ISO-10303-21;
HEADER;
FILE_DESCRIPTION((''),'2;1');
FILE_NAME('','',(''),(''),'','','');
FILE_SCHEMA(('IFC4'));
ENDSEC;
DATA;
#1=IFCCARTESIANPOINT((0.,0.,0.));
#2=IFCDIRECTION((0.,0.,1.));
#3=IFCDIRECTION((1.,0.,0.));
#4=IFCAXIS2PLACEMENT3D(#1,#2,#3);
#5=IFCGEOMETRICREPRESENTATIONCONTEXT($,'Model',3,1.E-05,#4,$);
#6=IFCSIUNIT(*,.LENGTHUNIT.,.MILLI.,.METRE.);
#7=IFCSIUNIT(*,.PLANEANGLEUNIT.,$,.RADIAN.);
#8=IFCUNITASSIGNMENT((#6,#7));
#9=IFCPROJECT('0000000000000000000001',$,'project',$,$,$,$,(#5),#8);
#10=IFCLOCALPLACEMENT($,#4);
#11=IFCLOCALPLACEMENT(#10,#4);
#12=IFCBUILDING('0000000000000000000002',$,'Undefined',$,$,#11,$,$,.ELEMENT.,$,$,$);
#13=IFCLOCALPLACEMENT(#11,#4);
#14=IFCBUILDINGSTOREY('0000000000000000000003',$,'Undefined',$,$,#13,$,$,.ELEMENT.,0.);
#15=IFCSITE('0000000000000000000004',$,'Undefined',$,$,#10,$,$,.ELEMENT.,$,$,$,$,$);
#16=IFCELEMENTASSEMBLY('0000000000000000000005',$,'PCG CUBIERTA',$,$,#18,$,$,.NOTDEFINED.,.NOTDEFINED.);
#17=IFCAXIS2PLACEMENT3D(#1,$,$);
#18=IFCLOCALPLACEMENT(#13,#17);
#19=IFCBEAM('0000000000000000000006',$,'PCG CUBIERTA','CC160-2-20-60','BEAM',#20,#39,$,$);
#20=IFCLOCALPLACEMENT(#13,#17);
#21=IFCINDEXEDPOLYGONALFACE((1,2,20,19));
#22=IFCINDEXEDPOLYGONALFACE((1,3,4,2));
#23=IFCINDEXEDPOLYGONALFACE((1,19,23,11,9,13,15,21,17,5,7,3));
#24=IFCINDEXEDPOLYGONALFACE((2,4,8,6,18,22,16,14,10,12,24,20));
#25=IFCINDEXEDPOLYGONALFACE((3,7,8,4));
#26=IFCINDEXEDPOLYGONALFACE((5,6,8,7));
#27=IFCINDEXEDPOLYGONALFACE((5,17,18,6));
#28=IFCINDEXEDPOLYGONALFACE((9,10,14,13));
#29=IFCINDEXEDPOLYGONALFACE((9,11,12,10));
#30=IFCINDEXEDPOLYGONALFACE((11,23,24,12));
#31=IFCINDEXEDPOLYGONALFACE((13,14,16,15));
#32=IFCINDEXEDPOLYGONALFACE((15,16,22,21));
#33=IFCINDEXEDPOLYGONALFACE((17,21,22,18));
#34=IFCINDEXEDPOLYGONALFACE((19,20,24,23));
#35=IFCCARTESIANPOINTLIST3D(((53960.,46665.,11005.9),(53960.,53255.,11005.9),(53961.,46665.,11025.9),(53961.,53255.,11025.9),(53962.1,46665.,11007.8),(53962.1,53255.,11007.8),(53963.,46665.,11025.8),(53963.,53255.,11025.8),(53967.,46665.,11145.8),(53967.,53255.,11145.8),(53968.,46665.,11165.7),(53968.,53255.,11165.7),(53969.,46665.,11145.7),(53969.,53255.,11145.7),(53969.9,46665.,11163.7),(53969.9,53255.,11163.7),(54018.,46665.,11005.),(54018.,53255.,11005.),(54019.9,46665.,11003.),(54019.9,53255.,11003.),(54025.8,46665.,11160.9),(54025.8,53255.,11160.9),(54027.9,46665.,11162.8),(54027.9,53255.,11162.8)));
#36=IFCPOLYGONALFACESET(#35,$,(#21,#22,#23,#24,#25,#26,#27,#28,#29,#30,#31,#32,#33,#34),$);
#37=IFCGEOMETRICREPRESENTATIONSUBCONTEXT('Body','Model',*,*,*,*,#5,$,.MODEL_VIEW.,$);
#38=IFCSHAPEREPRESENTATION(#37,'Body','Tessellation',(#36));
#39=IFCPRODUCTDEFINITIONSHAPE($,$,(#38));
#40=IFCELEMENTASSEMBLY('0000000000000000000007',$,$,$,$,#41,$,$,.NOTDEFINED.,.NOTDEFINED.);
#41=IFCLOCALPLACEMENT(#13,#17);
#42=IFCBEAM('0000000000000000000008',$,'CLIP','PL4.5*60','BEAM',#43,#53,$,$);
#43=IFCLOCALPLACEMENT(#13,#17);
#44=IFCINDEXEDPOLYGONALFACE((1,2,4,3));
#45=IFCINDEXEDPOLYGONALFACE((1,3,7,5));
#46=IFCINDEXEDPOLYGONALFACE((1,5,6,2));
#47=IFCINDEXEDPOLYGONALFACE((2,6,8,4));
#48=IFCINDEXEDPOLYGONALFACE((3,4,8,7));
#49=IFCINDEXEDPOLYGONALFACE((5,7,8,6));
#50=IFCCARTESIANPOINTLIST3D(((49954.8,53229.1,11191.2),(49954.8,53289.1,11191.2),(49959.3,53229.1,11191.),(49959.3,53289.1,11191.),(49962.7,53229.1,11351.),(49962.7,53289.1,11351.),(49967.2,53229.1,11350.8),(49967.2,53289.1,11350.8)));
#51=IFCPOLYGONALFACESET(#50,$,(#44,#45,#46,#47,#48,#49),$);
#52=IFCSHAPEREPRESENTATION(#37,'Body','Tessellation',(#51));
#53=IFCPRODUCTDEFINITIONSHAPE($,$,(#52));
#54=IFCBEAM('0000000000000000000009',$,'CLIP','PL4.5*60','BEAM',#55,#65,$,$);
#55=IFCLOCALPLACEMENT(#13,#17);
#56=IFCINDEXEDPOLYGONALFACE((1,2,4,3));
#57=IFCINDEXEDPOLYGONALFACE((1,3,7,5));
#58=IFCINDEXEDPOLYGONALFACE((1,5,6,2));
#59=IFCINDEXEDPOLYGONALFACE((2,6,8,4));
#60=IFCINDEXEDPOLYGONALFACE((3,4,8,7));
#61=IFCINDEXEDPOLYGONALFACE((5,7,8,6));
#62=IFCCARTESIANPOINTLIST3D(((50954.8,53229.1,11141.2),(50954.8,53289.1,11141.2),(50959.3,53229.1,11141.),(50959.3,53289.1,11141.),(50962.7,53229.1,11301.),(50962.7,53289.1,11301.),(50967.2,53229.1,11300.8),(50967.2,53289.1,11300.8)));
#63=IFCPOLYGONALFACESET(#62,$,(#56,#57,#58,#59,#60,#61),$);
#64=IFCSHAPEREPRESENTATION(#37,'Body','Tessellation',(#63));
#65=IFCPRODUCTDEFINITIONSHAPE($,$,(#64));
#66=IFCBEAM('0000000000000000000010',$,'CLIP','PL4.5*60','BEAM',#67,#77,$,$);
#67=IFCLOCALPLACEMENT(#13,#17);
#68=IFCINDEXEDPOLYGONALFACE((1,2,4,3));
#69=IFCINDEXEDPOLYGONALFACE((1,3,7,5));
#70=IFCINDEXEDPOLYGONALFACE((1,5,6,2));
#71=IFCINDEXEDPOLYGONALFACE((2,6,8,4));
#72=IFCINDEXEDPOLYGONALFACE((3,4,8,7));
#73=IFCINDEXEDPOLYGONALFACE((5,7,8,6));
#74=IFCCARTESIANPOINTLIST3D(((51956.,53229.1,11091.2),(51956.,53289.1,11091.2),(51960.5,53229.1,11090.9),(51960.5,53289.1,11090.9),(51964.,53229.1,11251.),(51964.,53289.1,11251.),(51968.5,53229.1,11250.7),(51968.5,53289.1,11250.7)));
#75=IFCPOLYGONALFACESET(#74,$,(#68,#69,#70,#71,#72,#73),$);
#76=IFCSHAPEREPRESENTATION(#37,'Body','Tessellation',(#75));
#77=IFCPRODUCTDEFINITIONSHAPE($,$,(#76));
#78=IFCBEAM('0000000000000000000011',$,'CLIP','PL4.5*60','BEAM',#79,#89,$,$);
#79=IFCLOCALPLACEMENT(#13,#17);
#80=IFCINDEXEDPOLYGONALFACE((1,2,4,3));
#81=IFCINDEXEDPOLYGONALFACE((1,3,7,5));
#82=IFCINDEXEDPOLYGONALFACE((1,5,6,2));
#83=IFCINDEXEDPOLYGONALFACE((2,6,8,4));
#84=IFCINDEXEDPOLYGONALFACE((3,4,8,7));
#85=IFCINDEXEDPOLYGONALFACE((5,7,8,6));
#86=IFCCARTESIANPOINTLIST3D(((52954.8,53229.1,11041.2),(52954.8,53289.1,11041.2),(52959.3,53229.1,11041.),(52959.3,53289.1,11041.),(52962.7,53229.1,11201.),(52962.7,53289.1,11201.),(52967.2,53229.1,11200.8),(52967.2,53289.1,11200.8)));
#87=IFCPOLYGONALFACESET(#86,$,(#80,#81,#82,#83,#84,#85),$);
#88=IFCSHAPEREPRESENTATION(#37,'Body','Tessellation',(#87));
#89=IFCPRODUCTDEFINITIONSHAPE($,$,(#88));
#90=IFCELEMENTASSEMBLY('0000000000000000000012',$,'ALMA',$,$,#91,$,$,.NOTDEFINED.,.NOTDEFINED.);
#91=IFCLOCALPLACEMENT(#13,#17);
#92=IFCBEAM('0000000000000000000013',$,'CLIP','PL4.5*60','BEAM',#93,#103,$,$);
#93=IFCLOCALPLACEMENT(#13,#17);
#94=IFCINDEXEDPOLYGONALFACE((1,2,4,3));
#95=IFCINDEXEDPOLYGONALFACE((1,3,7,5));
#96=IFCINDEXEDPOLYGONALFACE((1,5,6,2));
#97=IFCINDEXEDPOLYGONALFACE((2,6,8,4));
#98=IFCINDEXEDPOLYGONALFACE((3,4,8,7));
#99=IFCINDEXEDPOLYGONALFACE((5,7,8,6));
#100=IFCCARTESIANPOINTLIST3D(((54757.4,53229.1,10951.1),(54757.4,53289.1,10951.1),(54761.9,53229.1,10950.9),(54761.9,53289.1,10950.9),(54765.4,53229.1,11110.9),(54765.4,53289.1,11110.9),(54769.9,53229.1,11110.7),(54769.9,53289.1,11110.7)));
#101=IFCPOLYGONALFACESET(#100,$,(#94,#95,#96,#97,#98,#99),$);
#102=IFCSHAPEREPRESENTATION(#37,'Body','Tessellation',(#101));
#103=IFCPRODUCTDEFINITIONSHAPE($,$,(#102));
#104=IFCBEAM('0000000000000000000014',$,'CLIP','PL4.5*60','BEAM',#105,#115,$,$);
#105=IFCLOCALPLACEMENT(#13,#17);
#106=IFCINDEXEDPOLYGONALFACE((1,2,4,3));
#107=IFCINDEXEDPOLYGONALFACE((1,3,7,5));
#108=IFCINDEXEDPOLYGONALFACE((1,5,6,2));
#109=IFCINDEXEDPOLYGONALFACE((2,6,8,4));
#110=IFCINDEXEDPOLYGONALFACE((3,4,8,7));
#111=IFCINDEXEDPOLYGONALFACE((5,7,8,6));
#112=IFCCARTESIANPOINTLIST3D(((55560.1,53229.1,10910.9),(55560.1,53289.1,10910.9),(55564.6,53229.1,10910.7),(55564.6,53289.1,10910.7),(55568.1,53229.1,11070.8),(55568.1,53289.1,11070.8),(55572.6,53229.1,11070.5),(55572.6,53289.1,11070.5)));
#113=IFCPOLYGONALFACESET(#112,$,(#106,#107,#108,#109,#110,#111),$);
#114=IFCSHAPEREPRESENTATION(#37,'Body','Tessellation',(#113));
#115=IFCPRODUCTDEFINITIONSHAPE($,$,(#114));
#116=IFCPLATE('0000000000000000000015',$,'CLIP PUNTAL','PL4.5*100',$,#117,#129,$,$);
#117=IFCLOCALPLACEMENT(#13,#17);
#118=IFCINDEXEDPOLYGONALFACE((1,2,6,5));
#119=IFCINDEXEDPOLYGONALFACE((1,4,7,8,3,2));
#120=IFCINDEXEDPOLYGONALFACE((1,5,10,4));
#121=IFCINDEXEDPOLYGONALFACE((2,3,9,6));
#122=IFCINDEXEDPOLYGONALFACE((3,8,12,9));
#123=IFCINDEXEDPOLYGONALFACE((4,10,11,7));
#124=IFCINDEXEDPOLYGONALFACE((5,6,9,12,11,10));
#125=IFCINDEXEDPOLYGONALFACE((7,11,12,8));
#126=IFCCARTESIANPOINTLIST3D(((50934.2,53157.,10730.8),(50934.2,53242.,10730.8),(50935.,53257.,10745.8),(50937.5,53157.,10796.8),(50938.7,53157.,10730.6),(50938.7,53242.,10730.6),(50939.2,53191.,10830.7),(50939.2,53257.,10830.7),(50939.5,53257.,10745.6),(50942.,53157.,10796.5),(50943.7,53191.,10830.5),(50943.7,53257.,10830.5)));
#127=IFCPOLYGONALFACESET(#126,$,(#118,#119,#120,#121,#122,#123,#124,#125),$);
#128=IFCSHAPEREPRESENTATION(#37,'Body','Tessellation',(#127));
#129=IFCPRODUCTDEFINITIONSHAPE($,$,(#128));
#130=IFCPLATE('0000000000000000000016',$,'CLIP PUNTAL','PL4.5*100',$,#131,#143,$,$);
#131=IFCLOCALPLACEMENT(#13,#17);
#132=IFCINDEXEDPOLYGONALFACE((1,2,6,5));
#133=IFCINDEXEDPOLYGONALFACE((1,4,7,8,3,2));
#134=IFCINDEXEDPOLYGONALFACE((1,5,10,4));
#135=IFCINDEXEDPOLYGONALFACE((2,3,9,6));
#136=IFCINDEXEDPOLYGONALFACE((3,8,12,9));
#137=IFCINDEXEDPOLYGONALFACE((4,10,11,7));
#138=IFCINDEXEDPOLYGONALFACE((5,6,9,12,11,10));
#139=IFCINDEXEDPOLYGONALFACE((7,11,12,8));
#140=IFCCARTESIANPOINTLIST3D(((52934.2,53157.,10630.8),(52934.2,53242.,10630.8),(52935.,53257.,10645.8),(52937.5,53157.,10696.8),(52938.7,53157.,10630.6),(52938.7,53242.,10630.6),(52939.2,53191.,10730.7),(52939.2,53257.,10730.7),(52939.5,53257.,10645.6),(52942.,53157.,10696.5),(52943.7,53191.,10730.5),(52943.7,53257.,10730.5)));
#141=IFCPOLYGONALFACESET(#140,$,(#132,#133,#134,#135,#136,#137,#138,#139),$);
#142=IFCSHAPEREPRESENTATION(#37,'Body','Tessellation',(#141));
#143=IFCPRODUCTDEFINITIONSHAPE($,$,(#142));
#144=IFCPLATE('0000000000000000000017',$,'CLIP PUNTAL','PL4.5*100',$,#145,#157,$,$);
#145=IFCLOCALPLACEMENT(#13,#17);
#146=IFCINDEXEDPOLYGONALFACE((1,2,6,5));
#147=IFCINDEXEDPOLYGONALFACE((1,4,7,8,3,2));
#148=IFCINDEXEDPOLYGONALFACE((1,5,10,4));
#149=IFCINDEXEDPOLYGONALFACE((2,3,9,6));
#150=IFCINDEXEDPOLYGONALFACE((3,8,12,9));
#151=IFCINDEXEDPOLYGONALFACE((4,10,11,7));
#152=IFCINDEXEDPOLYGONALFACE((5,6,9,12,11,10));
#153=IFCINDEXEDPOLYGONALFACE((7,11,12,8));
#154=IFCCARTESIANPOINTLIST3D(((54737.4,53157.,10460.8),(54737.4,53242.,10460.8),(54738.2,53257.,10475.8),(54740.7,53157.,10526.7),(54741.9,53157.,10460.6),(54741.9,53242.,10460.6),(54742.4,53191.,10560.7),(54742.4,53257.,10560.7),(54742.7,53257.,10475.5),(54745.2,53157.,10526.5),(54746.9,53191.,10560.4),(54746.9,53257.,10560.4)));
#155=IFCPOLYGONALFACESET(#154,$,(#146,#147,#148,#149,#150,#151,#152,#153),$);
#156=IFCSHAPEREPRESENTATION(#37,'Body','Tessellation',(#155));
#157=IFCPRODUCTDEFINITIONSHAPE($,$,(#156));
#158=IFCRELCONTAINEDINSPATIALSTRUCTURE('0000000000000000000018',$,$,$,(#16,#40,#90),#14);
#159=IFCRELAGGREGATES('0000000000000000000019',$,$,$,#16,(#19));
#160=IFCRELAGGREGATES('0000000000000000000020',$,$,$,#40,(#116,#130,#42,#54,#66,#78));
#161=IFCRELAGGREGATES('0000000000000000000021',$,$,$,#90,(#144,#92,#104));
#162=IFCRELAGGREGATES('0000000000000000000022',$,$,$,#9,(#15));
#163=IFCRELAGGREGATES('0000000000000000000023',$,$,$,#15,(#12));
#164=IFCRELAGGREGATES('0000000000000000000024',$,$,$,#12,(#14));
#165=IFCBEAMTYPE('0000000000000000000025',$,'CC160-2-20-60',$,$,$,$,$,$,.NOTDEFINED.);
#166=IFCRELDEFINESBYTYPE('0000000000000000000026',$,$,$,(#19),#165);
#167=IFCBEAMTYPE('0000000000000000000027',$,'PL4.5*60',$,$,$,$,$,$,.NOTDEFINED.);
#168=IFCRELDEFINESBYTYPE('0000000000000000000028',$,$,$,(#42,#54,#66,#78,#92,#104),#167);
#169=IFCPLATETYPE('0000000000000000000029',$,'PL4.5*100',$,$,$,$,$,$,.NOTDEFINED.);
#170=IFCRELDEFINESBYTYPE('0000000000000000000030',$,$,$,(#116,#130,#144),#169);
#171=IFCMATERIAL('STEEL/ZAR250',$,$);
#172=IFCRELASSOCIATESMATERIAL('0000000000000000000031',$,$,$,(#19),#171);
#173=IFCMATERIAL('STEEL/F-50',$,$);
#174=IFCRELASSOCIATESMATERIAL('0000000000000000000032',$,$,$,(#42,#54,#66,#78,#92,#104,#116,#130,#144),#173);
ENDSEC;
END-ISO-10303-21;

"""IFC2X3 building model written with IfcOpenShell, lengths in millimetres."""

from ifc_helpers import new_model, si_unit, frame, origin_with_axes, origin_2d_with_axis, place, context, subcontext, project, spatial, polyline, rectangle, c_section, outline, extrude, material, type_object, element, aggregate, save


model = new_model("IFC2X3")

# Units and contexts
model_context = context("Model", 3, precision=1e-05, world=origin_with_axes())
body_context = subcontext(model_context, "Body", "Model", "MODEL_VIEW")
ifc_project = project(units=[si_unit("LENGTHUNIT", "METRE", prefix="MILLI"), si_unit("PLANEANGLEUNIT", "RADIAN")], contexts=[model_context])

# Site, building, storey
site_placement = place(None, origin_with_axes())
site = spatial("IfcSite", under=ifc_project, at=site_placement, Name="Undefined", CompositionType="ELEMENT")
building_placement = place(site_placement, origin_with_axes())
building = spatial("IfcBuilding", under=site, at=building_placement, Name="Undefined", CompositionType="ELEMENT")
storey_placement = place(building_placement, origin_with_axes())
storey = spatial("IfcBuildingStorey", under=building, at=storey_placement, Name="Undefined", CompositionType="ELEMENT", Elevation=0.0)

# Element assembly, beam
assembly_1_placement = place(storey_placement, origin_with_axes())
assembly_1 = element("IfcElementAssembly", 1, at=assembly_1_placement, inside=storey, Name="PCG CUBIERTA", AssemblyPlace="NOTDEFINED", PredefinedType="NOTDEFINED")
ifc_material_1 = material(Name="STEEL/ZAR250")
beam_type_1 = type_object("IfcBeamType", Name="CC160-2-20-60", PredefinedType="NOTDEFINED")
beam_1_placement = place(assembly_1_placement, frame((53994.0, 53255.0, 11084.4), z_axis=(0.049943, 0.0, 0.998752), x_axis=(0.0, -1.0, 0.0)))
beam_1 = element("IfcBeam", 2, at=beam_1_placement, type_object=beam_type_1, material=ifc_material_1, Name="PCG CUBIERTA", Description="CC160-2-20-60", ObjectType="BEAM", context=body_context, shape_type="SweptSolid", body=[
    extrude(c_section(Depth=160.0, Width=60.0, WallThickness=2.0, Girth=20.0, at=origin_2d_with_axis()), frame((6590.0, 0.0, 0.0), z_axis=(-1.0, 0.0, 0.0), x_axis=(0.0, -1.0, 0.0)), (0.0, 0.0, 1.0), 6590.0),
])

# Element assemblies, beams
assembly_2_placement = place(storey_placement, origin_with_axes())
assembly_2 = element("IfcElementAssembly", 3, at=assembly_2_placement, inside=storey, AssemblyPlace="NOTDEFINED", PredefinedType="NOTDEFINED")
ifc_material_2 = material(Name="STEEL/F-50")
beam_type_2 = type_object("IfcBeamType", Name="PL4.5*60", PredefinedType="NOTDEFINED")
beam_2_placement = place(assembly_2_placement, frame((49965.0, 53259.1, 11350.9), z_axis=(0.0, 1.0, 0.0), x_axis=(-0.049943, 0.0, -0.998752)))
beam_2 = element("IfcBeam", 4, at=beam_2_placement, type_object=beam_type_2, material=ifc_material_2, Name="CLIP", Description="PL4.5*60", ObjectType="BEAM", context=body_context, shape_type="SweptSolid", body=[
    extrude(rectangle(XDim=4.5, YDim=60.0, at=origin_2d_with_axis()), frame((160.0, 0.0, 0.0), z_axis=(-1.0, 0.0, 0.0), x_axis=(0.0, -1.0, 0.0)), (0.0, 0.0, 1.0), 160.0),
])
beam_3_placement = place(assembly_2_placement, frame((50965.0, 53259.1, 11300.9), z_axis=(0.0, 1.0, 0.0), x_axis=(-0.049943, 0.0, -0.998752)))
beam_3 = element("IfcBeam", 5, at=beam_3_placement, type_object=beam_type_2, material=ifc_material_2, Name="CLIP", Description="PL4.5*60", ObjectType="BEAM", context=body_context, shape_type="SweptSolid", body=[
    extrude(rectangle(XDim=4.5, YDim=60.0, at=origin_2d_with_axis()), frame((160.0, 0.0, 0.0), z_axis=(-1.0, 0.0, 0.0), x_axis=(0.0, -1.0, 0.0)), (0.0, 0.0, 1.0), 160.0),
])
beam_4_placement = place(assembly_2_placement, frame((51966.2, 53259.1, 11250.9), z_axis=(0.0, 1.0, 0.0), x_axis=(-0.049943, 0.0, -0.998752)))
beam_4 = element("IfcBeam", 6, at=beam_4_placement, type_object=beam_type_2, material=ifc_material_2, Name="CLIP", Description="PL4.5*60", ObjectType="BEAM", context=body_context, shape_type="SweptSolid", body=[
    extrude(rectangle(XDim=4.5, YDim=60.0, at=origin_2d_with_axis()), frame((160.0, 0.0, 0.0), z_axis=(-1.0, 0.0, 0.0), x_axis=(0.0, -1.0, 0.0)), (0.0, 0.0, 1.0), 160.0),
])
beam_5_placement = place(assembly_2_placement, frame((52965.0, 53259.1, 11200.9), z_axis=(0.0, 1.0, 0.0), x_axis=(-0.049943, 0.0, -0.998752)))
beam_5 = element("IfcBeam", 7, at=beam_5_placement, type_object=beam_type_2, material=ifc_material_2, Name="CLIP", Description="PL4.5*60", ObjectType="BEAM", context=body_context, shape_type="SweptSolid", body=[
    extrude(rectangle(XDim=4.5, YDim=60.0, at=origin_2d_with_axis()), frame((160.0, 0.0, 0.0), z_axis=(-1.0, 0.0, 0.0), x_axis=(0.0, -1.0, 0.0)), (0.0, 0.0, 1.0), 160.0),
])
assembly_3_placement = place(storey_placement, origin_with_axes())
assembly_3 = element("IfcElementAssembly", 8, at=assembly_3_placement, inside=storey, Name="ALMA", AssemblyPlace="NOTDEFINED", PredefinedType="NOTDEFINED")
beam_6_placement = place(assembly_3_placement, frame((54767.7, 53259.1, 11110.8), z_axis=(0.0, 1.0, 0.0), x_axis=(-0.049943, 0.0, -0.998752)))
beam_6 = element("IfcBeam", 9, at=beam_6_placement, type_object=beam_type_2, material=ifc_material_2, Name="CLIP", Description="PL4.5*60", ObjectType="BEAM", context=body_context, shape_type="SweptSolid", body=[
    extrude(rectangle(XDim=4.5, YDim=60.0, at=origin_2d_with_axis()), frame((160.0, 0.0, 0.0), z_axis=(-1.0, 0.0, 0.0), x_axis=(0.0, -1.0, 0.0)), (0.0, 0.0, 1.0), 160.0),
])
beam_7_placement = place(assembly_3_placement, frame((55570.4, 53259.1, 11070.6), z_axis=(0.0, 1.0, 0.0), x_axis=(-0.049943, 0.0, -0.998752)))
beam_7 = element("IfcBeam", 10, at=beam_7_placement, type_object=beam_type_2, material=ifc_material_2, Name="CLIP", Description="PL4.5*60", ObjectType="BEAM", context=body_context, shape_type="SweptSolid", body=[
    extrude(rectangle(XDim=4.5, YDim=60.0, at=origin_2d_with_axis()), frame((160.0, 0.0, 0.0), z_axis=(-1.0, 0.0, 0.0), x_axis=(0.0, -1.0, 0.0)), (0.0, 0.0, 1.0), 160.0),
])

# Plates
plate_type = type_object("IfcPlateType", Name="PL4.5*100", PredefinedType="NOTDEFINED")
plate_1_placement = place(assembly_2_placement, frame((50941.5, 53257.0, 10830.6), z_axis=(0.998754, 0.0, -0.049896), x_axis=(0.0, -1.0, 0.0)))
plate_1 = element("IfcPlate", 11, at=plate_1_placement, type_object=plate_type, material=ifc_material_2, Name="CLIP PUNTAL", Description="PL4.5*100", context=body_context, shape_type="SweptSolid", body=[
    extrude(outline(polyline([(0.0, 0.0), (66.0, 0.0), (100.0, 34.0), (100.0, 100.0), (15.0, 100.0), (0.0, 85.0), (0.0, 0.0)])), frame((0.0, 0.0, -2.2), z_axis=(0.0, 0.0, 1.0), x_axis=(1.0, 0.0, 0.0)), (0.0, 0.0, 1.0), 4.5),
])
plate_2_placement = place(assembly_2_placement, frame((52941.5, 53257.0, 10730.6), z_axis=(0.998754, 0.0, -0.049896), x_axis=(0.0, -1.0, 0.0)))
plate_2 = element("IfcPlate", 12, at=plate_2_placement, type_object=plate_type, material=ifc_material_2, Name="CLIP PUNTAL", Description="PL4.5*100", context=body_context, shape_type="SweptSolid", body=[
    extrude(outline(polyline([(0.0, 0.0), (66.0, 0.0), (100.0, 34.0), (100.0, 100.0), (15.0, 100.0), (0.0, 85.0), (0.0, 0.0)])), frame((0.0, 0.0, -2.2), z_axis=(0.0, 0.0, 1.0), x_axis=(1.0, 0.0, 0.0)), (0.0, 0.0, 1.0), 4.5),
])
plate_3_placement = place(assembly_3_placement, frame((54744.7, 53257.0, 10560.5), z_axis=(0.998754, 0.0, -0.049896), x_axis=(0.0, -1.0, 0.0)))
plate_3 = element("IfcPlate", 13, at=plate_3_placement, type_object=plate_type, material=ifc_material_2, Name="CLIP PUNTAL", Description="PL4.5*100", context=body_context, shape_type="SweptSolid", body=[
    extrude(outline(polyline([(0.0, 0.0), (66.0, 0.0), (100.0, 34.0), (100.0, 100.0), (15.0, 100.0), (0.0, 85.0), (0.0, 0.0)])), frame((0.0, 0.0, -2.2), z_axis=(0.0, 0.0, 1.0), x_axis=(1.0, 0.0, 0.0)), (0.0, 0.0, 1.0), 4.5),
])

aggregate(assembly_1, [beam_1])

aggregate(assembly_2, [plate_1, plate_2, beam_2, beam_3, beam_4, beam_5])
aggregate(assembly_3, [plate_3, beam_6, beam_7])

save(model, "model.ifc")
